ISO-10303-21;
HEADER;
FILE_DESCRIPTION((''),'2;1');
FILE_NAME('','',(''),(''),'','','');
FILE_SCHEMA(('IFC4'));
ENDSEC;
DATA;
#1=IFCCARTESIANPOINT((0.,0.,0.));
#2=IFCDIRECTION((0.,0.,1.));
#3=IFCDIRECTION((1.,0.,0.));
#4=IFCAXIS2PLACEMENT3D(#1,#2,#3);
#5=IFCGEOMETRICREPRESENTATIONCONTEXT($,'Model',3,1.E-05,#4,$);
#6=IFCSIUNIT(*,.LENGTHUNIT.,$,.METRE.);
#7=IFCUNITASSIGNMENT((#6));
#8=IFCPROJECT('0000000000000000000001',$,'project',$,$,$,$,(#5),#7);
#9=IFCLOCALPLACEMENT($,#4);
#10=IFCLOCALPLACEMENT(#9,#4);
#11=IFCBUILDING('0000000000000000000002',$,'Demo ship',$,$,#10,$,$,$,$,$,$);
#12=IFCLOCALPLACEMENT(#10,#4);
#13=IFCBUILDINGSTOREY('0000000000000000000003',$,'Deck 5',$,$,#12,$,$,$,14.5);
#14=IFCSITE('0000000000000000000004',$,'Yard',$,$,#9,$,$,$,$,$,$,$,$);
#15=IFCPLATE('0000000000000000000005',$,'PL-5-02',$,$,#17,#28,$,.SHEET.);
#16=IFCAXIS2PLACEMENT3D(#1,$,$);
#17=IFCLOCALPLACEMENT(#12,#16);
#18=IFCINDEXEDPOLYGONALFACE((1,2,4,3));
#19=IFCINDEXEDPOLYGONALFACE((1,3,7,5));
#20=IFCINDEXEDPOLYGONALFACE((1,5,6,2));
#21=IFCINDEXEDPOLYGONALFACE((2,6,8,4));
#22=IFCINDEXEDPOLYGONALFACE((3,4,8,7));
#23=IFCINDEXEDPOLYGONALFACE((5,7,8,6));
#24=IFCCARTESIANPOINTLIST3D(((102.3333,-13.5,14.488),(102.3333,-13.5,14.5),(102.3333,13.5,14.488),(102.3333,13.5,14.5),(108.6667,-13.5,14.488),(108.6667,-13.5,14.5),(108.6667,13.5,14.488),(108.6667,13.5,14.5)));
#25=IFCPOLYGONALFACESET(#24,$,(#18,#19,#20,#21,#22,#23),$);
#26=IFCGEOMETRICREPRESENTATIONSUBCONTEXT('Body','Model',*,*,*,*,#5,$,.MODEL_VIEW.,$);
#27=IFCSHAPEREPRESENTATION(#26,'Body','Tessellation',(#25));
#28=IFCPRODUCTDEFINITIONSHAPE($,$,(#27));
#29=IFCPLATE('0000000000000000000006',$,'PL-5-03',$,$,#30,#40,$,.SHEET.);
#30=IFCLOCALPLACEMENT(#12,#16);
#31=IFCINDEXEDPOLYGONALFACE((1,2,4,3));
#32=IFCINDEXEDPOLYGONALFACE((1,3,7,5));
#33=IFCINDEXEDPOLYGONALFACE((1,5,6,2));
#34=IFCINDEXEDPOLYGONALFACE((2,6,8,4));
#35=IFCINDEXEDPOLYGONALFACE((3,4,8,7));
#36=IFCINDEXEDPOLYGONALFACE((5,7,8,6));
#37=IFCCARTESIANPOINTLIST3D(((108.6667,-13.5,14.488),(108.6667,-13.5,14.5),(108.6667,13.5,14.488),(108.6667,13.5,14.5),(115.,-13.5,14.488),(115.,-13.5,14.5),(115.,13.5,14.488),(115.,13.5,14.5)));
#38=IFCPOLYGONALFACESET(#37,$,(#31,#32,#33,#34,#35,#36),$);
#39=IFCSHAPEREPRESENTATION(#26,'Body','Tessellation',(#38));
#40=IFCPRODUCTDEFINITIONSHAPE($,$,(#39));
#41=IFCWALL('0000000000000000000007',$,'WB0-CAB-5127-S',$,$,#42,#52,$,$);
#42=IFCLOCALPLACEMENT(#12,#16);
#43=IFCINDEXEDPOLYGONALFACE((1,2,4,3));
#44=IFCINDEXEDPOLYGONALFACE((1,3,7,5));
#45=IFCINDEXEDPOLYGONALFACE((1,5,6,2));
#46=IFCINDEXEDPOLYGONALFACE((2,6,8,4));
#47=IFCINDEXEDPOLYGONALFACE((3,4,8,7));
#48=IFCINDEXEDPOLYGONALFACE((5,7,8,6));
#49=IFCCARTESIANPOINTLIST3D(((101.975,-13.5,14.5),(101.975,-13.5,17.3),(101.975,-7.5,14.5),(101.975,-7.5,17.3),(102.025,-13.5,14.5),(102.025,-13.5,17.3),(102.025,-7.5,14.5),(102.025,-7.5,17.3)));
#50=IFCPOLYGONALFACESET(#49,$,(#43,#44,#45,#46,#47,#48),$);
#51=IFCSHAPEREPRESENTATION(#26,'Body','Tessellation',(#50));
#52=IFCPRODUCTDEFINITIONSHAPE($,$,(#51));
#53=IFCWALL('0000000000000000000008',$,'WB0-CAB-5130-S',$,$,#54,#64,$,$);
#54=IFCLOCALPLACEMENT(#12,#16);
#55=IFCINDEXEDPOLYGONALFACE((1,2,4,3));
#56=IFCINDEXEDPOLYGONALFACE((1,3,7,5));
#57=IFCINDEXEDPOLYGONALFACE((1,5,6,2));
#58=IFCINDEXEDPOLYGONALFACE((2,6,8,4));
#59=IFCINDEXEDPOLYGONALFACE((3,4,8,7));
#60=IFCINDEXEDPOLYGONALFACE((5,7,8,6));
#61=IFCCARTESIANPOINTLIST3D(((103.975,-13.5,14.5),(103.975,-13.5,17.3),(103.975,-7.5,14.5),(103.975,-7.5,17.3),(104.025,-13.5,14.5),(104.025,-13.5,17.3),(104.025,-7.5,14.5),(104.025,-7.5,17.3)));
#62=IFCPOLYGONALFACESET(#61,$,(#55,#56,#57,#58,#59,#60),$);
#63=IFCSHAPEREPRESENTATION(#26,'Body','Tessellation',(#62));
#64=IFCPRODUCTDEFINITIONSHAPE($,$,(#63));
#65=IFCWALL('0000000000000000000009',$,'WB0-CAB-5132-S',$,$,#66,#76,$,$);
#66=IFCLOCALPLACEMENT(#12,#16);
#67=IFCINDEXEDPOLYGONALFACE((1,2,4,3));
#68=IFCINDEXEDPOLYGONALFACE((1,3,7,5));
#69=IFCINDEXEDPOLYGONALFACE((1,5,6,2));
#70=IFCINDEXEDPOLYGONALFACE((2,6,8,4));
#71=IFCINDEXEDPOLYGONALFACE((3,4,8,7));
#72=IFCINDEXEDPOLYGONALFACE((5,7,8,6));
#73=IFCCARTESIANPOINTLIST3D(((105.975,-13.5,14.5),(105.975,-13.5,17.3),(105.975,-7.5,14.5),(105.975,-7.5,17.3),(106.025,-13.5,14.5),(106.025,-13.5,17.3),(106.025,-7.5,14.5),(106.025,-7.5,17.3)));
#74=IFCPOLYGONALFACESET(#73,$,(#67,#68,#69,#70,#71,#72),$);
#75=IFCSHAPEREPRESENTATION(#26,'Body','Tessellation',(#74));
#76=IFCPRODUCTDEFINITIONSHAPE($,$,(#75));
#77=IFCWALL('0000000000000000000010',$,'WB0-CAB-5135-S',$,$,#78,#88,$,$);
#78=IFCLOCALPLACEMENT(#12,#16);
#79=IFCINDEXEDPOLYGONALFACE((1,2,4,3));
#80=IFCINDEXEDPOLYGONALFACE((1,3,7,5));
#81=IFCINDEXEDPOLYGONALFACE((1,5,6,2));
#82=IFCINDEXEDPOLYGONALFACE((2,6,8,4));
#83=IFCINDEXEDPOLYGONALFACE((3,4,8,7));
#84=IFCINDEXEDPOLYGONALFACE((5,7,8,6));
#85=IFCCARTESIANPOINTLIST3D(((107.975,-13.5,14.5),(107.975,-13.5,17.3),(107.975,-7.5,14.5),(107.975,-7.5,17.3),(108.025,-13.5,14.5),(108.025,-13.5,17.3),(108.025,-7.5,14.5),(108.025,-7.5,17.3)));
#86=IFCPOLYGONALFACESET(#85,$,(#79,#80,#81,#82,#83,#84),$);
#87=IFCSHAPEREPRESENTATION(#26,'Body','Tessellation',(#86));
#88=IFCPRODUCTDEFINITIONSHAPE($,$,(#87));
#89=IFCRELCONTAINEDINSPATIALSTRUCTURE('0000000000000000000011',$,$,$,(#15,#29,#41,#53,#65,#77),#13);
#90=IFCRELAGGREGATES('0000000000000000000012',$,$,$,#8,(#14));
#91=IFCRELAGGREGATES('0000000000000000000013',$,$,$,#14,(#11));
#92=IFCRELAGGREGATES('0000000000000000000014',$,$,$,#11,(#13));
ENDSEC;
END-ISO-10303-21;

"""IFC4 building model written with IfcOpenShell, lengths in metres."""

from ifc_helpers import new_model, si_unit, frame, frame_2d, origin, origin_with_axes, place, context, subcontext, project, spatial, rectangle, extrude, element, save


model = new_model("IFC4")

# Units and contexts
model_context = context("Model", 3, precision=1e-05, world=origin_with_axes())
body_context = subcontext(model_context, "Body", "Model", "MODEL_VIEW")
ifc_project = project(units=[si_unit("LENGTHUNIT", "METRE")], contexts=[model_context])

# Site, building, storey
site_placement = place(None, origin_with_axes())
site = spatial("IfcSite", under=ifc_project, at=site_placement, Name="Yard")
building_placement = place(site_placement, origin_with_axes())
building = spatial("IfcBuilding", under=site, at=building_placement, Name="Demo ship")
storey_placement = place(building_placement, origin_with_axes())
storey = spatial("IfcBuildingStorey", under=building, at=storey_placement, Name="Deck 5", Elevation=14.5)

# Plates
plate_1_placement = place(storey_placement, frame((102.3333, -13.5, 14.488), z_axis=(0.0, 0.0, 1.0), x_axis=(1.0, 0.0, 0.0)))
element("IfcPlate", 1, at=plate_1_placement, inside=storey, Name="PL-5-02", PredefinedType="SHEET", context=body_context, shape_type="SweptSolid", body=[
    extrude(rectangle(XDim=6.3334, YDim=27.0, at=frame_2d((3.1667, 13.5))), origin(), (0.0, 0.0, 1.0), 0.012),
])
plate_2_placement = place(storey_placement, frame((108.6667, -13.5, 14.488), z_axis=(0.0, 0.0, 1.0), x_axis=(1.0, 0.0, 0.0)))
element("IfcPlate", 2, at=plate_2_placement, inside=storey, Name="PL-5-03", PredefinedType="SHEET", context=body_context, shape_type="SweptSolid", body=[
    extrude(rectangle(XDim=6.3333, YDim=27.0, at=frame_2d((3.1666, 13.5))), origin(), (0.0, 0.0, 1.0), 0.012),
])

# Walls
for number, where, z_axis, x_axis, name in (
    (3, (101.975, -13.5, 14.5), (0.0, 0.0, 1.0), (1.0, 0.0, 0.0), "WB0-CAB-5127-S"),
    (4, (103.975, -13.5, 14.5), (0.0, 0.0, 1.0), (1.0, 0.0, 0.0), "WB0-CAB-5130-S"),
    (5, (105.975, -13.5, 14.5), (0.0, 0.0, 1.0), (1.0, 0.0, 0.0), "WB0-CAB-5132-S"),
    (6, (107.975, -13.5, 14.5), (0.0, 0.0, 1.0), (1.0, 0.0, 0.0), "WB0-CAB-5135-S"),
):
    element("IfcWall", number, at=place(storey_placement, frame(where, z_axis=z_axis, x_axis=x_axis)), inside=storey, Name=name, context=body_context, shape_type="SweptSolid", body=[
        extrude(rectangle(XDim=0.05, YDim=6.0, at=frame_2d((0.025, 3.0))), origin(), (0.0, 0.0, 1.0), 2.8),
    ])

save(model, "model.ifc")
